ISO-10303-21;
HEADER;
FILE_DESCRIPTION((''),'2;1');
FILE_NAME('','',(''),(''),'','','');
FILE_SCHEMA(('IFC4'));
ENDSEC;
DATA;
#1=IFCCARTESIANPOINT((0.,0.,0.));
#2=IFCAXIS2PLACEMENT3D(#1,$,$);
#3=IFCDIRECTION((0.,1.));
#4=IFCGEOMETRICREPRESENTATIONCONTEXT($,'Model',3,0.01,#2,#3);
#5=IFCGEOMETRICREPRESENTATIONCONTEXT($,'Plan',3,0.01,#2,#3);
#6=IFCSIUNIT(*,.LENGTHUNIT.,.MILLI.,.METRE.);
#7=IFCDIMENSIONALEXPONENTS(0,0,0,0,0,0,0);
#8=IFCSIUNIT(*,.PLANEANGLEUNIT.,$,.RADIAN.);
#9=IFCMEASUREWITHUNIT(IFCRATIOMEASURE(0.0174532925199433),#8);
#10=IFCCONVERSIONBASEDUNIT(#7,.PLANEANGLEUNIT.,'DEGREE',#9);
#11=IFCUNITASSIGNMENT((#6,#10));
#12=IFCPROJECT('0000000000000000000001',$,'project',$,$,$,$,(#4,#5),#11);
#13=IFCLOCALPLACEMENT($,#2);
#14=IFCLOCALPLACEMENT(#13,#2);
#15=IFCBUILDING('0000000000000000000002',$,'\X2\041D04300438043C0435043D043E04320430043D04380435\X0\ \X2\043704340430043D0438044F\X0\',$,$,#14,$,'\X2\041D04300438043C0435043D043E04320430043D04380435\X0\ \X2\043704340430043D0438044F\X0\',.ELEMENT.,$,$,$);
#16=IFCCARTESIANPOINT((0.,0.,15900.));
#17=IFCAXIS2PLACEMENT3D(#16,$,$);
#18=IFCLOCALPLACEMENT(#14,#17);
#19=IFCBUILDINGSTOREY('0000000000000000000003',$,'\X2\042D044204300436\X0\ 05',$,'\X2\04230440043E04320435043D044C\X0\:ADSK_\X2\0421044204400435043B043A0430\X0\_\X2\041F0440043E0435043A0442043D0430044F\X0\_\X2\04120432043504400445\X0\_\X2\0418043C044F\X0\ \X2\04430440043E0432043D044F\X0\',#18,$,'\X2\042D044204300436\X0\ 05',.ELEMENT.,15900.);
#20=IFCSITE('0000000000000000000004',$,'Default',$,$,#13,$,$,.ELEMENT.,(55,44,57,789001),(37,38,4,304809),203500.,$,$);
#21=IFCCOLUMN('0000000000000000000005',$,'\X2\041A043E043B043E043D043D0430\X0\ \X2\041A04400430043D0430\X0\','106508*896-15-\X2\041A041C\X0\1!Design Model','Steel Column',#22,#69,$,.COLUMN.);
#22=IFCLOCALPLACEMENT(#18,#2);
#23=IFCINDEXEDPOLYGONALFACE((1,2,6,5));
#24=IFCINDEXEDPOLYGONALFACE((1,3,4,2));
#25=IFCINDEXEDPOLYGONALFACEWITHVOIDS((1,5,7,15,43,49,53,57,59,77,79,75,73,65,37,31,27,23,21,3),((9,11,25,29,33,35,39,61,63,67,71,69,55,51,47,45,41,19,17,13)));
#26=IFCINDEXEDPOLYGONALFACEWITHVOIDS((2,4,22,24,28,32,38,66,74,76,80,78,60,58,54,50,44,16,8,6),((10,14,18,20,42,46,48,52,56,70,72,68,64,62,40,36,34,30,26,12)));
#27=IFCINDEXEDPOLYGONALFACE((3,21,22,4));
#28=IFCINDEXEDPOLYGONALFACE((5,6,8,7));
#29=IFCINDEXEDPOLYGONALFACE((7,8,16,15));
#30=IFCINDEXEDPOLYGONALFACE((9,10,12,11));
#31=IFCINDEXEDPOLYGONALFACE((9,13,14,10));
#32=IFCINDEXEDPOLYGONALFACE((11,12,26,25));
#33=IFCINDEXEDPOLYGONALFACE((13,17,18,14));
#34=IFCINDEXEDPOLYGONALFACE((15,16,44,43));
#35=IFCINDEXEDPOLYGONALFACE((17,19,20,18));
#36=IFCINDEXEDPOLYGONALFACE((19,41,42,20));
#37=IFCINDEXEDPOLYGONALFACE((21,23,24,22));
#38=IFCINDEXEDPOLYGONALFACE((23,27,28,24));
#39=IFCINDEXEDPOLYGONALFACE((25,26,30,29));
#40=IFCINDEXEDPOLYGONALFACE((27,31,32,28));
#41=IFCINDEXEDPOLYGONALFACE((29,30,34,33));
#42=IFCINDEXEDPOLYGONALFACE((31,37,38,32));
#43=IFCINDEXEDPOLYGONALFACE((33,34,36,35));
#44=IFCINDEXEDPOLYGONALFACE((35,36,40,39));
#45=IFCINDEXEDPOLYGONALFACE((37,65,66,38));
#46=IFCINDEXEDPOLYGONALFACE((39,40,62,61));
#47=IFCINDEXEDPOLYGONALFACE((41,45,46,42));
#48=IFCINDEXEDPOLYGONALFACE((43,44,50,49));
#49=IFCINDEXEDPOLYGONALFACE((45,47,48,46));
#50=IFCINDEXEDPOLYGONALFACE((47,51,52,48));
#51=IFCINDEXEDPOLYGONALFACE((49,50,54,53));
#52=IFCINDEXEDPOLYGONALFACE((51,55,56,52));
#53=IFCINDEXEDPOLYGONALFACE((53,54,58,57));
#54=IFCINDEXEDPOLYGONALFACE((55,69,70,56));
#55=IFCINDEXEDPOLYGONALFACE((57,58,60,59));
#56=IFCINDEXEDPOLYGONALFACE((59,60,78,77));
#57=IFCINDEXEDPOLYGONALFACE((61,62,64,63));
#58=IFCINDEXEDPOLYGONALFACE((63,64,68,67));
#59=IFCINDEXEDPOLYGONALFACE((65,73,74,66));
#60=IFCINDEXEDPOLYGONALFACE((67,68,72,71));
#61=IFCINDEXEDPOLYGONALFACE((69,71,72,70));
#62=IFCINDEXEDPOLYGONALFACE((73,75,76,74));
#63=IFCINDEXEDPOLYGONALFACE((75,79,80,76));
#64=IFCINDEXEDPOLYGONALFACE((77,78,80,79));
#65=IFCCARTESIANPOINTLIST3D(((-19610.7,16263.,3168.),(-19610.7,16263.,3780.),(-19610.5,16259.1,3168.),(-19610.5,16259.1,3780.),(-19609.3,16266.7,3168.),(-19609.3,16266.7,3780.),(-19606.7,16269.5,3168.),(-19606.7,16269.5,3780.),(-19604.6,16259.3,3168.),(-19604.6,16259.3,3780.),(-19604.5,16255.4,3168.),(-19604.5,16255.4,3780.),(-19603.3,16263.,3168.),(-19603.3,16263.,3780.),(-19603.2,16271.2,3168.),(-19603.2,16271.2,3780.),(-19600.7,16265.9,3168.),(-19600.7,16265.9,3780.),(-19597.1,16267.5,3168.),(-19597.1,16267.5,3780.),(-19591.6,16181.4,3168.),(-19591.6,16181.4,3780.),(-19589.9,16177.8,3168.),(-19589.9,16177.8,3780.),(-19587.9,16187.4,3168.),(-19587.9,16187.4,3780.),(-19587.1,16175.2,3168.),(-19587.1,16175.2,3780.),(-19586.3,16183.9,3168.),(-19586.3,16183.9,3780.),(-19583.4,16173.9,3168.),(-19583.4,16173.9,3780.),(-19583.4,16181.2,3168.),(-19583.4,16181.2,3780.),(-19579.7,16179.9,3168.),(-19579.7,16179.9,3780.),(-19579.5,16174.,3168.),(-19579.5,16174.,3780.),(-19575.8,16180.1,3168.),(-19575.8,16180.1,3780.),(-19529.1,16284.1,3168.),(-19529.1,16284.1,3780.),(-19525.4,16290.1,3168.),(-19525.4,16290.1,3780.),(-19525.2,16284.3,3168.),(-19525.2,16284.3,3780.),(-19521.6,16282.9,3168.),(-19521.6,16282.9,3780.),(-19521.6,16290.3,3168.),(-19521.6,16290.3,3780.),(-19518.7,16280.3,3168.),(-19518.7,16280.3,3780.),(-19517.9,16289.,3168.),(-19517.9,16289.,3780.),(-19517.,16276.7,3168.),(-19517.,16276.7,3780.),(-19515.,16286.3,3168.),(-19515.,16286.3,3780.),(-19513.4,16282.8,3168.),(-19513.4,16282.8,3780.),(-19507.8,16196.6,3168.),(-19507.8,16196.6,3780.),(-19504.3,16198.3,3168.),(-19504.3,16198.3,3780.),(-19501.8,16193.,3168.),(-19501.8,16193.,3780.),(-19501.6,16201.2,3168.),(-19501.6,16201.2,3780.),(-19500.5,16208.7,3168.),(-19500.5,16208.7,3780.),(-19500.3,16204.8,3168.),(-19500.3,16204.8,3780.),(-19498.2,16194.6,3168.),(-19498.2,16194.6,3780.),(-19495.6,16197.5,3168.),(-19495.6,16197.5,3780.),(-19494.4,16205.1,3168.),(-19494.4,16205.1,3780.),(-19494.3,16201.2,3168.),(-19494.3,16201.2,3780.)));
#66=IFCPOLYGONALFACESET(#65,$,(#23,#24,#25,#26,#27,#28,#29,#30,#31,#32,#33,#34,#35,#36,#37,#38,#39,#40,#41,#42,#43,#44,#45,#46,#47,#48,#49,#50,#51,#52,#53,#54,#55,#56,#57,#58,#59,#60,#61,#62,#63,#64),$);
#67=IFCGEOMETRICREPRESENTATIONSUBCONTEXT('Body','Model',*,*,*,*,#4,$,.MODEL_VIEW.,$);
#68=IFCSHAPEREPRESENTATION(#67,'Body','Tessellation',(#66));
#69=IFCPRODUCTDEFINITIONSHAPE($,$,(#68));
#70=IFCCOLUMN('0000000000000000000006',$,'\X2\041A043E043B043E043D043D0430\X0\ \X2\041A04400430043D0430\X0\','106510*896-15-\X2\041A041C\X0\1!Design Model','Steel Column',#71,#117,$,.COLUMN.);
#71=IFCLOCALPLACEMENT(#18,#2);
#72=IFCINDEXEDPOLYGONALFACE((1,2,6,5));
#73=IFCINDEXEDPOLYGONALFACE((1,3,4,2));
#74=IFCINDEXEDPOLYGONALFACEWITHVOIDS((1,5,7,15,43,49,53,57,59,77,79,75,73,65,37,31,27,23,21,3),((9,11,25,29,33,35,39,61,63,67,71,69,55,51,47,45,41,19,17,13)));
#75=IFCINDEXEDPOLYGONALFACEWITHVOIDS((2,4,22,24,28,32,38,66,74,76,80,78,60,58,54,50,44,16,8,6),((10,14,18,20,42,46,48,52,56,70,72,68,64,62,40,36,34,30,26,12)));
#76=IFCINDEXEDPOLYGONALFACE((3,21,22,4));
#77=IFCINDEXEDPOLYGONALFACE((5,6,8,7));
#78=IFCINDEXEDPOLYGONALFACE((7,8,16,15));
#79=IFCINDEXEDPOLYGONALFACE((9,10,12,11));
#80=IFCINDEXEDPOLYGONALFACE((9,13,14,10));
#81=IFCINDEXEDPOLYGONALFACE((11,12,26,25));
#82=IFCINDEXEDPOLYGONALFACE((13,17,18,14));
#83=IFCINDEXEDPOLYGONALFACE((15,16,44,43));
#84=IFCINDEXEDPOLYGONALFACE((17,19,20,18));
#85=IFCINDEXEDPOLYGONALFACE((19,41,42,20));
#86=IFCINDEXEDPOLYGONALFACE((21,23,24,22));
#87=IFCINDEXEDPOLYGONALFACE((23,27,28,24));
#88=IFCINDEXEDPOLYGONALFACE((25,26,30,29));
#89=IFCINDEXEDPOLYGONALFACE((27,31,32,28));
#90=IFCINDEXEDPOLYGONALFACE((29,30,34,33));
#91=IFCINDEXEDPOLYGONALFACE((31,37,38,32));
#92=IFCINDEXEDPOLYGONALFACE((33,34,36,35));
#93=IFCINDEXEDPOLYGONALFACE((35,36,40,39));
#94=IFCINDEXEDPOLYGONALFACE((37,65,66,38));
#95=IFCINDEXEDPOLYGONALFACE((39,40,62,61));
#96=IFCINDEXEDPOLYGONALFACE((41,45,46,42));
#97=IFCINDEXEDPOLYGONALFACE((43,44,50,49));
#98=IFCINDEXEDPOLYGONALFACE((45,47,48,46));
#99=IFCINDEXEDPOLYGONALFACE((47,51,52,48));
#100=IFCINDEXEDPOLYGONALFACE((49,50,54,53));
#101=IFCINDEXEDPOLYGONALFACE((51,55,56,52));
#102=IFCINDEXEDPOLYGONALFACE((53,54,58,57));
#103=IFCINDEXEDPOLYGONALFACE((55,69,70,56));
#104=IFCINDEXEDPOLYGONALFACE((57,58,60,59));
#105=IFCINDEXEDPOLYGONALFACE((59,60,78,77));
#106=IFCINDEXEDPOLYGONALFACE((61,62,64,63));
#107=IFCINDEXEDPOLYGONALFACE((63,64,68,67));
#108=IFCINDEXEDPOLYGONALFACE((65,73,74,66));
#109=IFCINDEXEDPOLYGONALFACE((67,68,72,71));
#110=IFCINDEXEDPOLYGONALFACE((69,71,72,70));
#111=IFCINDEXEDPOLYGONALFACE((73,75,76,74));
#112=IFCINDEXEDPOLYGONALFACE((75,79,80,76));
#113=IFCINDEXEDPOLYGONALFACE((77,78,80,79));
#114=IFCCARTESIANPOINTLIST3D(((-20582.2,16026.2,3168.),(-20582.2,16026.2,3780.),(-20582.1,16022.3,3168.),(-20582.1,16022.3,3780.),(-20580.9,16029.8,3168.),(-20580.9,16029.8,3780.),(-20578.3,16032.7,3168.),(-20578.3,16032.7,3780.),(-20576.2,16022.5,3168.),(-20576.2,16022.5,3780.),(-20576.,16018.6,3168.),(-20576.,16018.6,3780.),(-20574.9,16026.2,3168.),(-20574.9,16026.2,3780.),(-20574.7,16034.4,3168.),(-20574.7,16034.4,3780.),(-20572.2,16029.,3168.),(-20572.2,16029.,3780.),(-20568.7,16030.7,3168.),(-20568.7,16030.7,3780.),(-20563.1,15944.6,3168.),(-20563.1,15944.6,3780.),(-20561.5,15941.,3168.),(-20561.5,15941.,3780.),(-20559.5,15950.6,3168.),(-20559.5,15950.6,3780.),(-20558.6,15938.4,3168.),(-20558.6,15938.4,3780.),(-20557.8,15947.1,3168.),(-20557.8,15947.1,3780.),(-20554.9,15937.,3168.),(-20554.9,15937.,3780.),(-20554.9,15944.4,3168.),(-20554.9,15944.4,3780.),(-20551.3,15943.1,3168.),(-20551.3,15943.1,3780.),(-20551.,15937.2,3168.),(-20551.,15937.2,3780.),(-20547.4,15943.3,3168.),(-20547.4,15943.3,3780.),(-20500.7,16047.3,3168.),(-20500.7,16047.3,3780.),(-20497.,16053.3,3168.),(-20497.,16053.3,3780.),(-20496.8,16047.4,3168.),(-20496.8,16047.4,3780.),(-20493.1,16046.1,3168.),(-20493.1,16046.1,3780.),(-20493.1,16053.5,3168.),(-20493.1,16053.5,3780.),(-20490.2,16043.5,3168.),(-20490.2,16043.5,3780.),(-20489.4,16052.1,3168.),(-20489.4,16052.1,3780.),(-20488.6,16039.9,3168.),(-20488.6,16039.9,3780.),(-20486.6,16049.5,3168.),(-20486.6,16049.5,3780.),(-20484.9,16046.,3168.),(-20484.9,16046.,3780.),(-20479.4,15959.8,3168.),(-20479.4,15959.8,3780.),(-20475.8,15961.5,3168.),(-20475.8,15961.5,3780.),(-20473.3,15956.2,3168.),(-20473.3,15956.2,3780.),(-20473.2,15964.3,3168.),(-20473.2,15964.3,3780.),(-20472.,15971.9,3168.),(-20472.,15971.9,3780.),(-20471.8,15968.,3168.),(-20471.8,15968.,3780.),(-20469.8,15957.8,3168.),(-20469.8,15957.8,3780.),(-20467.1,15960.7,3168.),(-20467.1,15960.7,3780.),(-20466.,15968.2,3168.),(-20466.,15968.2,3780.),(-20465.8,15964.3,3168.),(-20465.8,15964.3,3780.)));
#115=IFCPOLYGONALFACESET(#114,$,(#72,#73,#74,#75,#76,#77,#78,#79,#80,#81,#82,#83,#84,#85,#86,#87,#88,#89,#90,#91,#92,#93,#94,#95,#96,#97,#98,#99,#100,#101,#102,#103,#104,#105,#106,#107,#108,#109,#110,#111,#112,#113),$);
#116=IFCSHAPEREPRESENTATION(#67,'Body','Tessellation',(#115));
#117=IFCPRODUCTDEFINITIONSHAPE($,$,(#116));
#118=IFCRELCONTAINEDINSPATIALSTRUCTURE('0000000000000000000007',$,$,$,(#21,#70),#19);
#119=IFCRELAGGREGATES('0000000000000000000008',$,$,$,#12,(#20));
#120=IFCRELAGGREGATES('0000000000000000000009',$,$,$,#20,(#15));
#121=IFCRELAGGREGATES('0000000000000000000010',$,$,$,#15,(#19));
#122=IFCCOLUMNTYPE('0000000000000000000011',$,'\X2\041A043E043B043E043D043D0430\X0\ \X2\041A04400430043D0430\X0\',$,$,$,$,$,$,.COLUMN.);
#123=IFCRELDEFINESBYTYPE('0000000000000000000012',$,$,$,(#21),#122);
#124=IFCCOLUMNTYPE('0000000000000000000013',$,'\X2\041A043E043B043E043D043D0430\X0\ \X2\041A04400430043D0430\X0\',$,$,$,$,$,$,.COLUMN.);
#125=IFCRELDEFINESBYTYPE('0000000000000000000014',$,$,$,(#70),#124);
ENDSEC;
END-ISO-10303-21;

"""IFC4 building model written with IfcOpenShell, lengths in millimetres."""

from ifc_helpers import new_model, entity, si_unit, converted_unit, direction, frame, origin, place, context, subcontext, project, spatial, indexed_curve, outline, extrude, type_object, element, save


model = new_model("IFC4")

# Units and contexts
model_context = context("Model", 3, precision=0.01, world=origin(), true_north=direction((0.0, 1.0)))
plan_context = context("Plan", 3, precision=0.01, world=origin(), true_north=direction((0.0, 1.0)))
body_context = subcontext(model_context, "Body", "Model", "MODEL_VIEW")
ifc_project = project(units=[si_unit("LENGTHUNIT", "METRE", prefix="MILLI"), converted_unit("PLANEANGLEUNIT", "DEGREE", entity("IfcRatioMeasure", 0.0174532925199433), si_unit("PLANEANGLEUNIT", "RADIAN"), dimensions=[0, 0, 0, 0, 0, 0, 0])], contexts=[model_context, plan_context])

# Site, building, storey
site_placement = place(None, origin())
site = spatial("IfcSite", under=ifc_project, at=site_placement, Name="Default", CompositionType="ELEMENT", RefLatitude=(55, 44, 57, 789001), RefLongitude=(37, 38, 4, 304809), RefElevation=203500.0)
building_placement = place(site_placement, origin())
building = spatial("IfcBuilding", under=site, at=building_placement, Name="Наименование здания", LongName="Наименование здания", CompositionType="ELEMENT")
storey_placement = place(building_placement, frame((0.0, 0.0, 15900.0)))
storey = spatial("IfcBuildingStorey", under=building, at=storey_placement, Name="Этаж 05", ObjectType="Уровень:ADSK_Стрелка_Проектная_Вверх_Имя уровня", LongName="Этаж 05", CompositionType="ELEMENT", Elevation=15900.0)

# Columns
placement = place(storey_placement, origin())
column_type_1 = type_object("IfcColumnType", Name="Колонна Крана", PredefinedType="COLUMN")
element("IfcColumn", 1, at=placement, inside=storey, type_object=column_type_1, Name="Колонна Крана", Description="106508*896-15-КМ1!Design Model", ObjectType="Steel Column", PredefinedType="COLUMN", context=body_context, shape_type="SweptSolid", body=[
    extrude(outline(indexed_curve([(29.5, -56.8), (33.4, -56.8), (37.0, -55.3), (39.7, -52.6), (41.2, -49.0), (56.8, 29.5), (56.8, 33.4), (55.3, 37.0), (52.6, 39.7), (49.0, 41.2), (-29.5, 56.8), (-33.4, 56.8), (-37.0, 55.3), (-39.7, 52.6), (-41.2, 49.0), (-56.8, -29.5), (-56.8, -33.4), (-55.3, -37.0), (-52.6, -39.7), (-49.0, -41.2), (29.5, -56.8)], self_intersect=False), holes=[indexed_curve([(-43.1, -37.3), (-46.7, -35.8), (-49.5, -33.1), (-51.0, -29.5), (-51.0, -25.5), (-37.3, 43.1), (-35.8, 46.7), (-33.1, 49.5), (-29.5, 51.0), (-25.5, 51.0), (43.1, 37.3), (46.7, 35.8), (49.5, 33.1), (51.0, 29.5), (51.0, 25.5), (37.3, -43.1), (35.8, -46.7), (33.1, -49.5), (29.5, -51.0), (25.5, -51.0), (-43.1, -37.3)], self_intersect=False)]), frame((-19552.5, 16232.1, 3168.0), z_axis=(0.0, 0.0, 1.0), x_axis=(0.906681, 0.421816, 0.0)), (0.0, 0.0, 1.0), 612.0),
])
column_type_2 = type_object("IfcColumnType", Name="Колонна Крана", PredefinedType="COLUMN")
element("IfcColumn", 2, at=placement, inside=storey, type_object=column_type_2, Name="Колонна Крана", Description="106510*896-15-КМ1!Design Model", ObjectType="Steel Column", PredefinedType="COLUMN", context=body_context, shape_type="SweptSolid", body=[
    extrude(outline(indexed_curve([(29.5, -56.8), (33.4, -56.8), (37.0, -55.3), (39.7, -52.6), (41.2, -49.0), (56.8, 29.5), (56.8, 33.4), (55.3, 37.0), (52.6, 39.7), (49.0, 41.2), (-29.5, 56.8), (-33.4, 56.8), (-37.0, 55.3), (-39.7, 52.6), (-41.2, 49.0), (-56.8, -29.5), (-56.8, -33.4), (-55.3, -37.0), (-52.6, -39.7), (-49.0, -41.2), (29.5, -56.8)], self_intersect=False), holes=[indexed_curve([(-43.1, -37.3), (-46.7, -35.8), (-49.5, -33.1), (-51.0, -29.5), (-51.0, -25.5), (-37.3, 43.1), (-35.8, 46.7), (-33.1, 49.5), (-29.5, 51.0), (-25.5, 51.0), (43.1, 37.3), (46.7, 35.8), (49.5, 33.1), (51.0, 29.5), (51.0, 25.5), (37.3, -43.1), (35.8, -46.7), (33.1, -49.5), (29.5, -51.0), (25.5, -51.0), (-43.1, -37.3)], self_intersect=False)]), frame((-20524.0, 15995.3, 3168.0), z_axis=(0.0, 0.0, 1.0), x_axis=(0.906681, 0.421816, 0.0)), (0.0, 0.0, 1.0), 612.0),
])

save(model, "model.ifc")
